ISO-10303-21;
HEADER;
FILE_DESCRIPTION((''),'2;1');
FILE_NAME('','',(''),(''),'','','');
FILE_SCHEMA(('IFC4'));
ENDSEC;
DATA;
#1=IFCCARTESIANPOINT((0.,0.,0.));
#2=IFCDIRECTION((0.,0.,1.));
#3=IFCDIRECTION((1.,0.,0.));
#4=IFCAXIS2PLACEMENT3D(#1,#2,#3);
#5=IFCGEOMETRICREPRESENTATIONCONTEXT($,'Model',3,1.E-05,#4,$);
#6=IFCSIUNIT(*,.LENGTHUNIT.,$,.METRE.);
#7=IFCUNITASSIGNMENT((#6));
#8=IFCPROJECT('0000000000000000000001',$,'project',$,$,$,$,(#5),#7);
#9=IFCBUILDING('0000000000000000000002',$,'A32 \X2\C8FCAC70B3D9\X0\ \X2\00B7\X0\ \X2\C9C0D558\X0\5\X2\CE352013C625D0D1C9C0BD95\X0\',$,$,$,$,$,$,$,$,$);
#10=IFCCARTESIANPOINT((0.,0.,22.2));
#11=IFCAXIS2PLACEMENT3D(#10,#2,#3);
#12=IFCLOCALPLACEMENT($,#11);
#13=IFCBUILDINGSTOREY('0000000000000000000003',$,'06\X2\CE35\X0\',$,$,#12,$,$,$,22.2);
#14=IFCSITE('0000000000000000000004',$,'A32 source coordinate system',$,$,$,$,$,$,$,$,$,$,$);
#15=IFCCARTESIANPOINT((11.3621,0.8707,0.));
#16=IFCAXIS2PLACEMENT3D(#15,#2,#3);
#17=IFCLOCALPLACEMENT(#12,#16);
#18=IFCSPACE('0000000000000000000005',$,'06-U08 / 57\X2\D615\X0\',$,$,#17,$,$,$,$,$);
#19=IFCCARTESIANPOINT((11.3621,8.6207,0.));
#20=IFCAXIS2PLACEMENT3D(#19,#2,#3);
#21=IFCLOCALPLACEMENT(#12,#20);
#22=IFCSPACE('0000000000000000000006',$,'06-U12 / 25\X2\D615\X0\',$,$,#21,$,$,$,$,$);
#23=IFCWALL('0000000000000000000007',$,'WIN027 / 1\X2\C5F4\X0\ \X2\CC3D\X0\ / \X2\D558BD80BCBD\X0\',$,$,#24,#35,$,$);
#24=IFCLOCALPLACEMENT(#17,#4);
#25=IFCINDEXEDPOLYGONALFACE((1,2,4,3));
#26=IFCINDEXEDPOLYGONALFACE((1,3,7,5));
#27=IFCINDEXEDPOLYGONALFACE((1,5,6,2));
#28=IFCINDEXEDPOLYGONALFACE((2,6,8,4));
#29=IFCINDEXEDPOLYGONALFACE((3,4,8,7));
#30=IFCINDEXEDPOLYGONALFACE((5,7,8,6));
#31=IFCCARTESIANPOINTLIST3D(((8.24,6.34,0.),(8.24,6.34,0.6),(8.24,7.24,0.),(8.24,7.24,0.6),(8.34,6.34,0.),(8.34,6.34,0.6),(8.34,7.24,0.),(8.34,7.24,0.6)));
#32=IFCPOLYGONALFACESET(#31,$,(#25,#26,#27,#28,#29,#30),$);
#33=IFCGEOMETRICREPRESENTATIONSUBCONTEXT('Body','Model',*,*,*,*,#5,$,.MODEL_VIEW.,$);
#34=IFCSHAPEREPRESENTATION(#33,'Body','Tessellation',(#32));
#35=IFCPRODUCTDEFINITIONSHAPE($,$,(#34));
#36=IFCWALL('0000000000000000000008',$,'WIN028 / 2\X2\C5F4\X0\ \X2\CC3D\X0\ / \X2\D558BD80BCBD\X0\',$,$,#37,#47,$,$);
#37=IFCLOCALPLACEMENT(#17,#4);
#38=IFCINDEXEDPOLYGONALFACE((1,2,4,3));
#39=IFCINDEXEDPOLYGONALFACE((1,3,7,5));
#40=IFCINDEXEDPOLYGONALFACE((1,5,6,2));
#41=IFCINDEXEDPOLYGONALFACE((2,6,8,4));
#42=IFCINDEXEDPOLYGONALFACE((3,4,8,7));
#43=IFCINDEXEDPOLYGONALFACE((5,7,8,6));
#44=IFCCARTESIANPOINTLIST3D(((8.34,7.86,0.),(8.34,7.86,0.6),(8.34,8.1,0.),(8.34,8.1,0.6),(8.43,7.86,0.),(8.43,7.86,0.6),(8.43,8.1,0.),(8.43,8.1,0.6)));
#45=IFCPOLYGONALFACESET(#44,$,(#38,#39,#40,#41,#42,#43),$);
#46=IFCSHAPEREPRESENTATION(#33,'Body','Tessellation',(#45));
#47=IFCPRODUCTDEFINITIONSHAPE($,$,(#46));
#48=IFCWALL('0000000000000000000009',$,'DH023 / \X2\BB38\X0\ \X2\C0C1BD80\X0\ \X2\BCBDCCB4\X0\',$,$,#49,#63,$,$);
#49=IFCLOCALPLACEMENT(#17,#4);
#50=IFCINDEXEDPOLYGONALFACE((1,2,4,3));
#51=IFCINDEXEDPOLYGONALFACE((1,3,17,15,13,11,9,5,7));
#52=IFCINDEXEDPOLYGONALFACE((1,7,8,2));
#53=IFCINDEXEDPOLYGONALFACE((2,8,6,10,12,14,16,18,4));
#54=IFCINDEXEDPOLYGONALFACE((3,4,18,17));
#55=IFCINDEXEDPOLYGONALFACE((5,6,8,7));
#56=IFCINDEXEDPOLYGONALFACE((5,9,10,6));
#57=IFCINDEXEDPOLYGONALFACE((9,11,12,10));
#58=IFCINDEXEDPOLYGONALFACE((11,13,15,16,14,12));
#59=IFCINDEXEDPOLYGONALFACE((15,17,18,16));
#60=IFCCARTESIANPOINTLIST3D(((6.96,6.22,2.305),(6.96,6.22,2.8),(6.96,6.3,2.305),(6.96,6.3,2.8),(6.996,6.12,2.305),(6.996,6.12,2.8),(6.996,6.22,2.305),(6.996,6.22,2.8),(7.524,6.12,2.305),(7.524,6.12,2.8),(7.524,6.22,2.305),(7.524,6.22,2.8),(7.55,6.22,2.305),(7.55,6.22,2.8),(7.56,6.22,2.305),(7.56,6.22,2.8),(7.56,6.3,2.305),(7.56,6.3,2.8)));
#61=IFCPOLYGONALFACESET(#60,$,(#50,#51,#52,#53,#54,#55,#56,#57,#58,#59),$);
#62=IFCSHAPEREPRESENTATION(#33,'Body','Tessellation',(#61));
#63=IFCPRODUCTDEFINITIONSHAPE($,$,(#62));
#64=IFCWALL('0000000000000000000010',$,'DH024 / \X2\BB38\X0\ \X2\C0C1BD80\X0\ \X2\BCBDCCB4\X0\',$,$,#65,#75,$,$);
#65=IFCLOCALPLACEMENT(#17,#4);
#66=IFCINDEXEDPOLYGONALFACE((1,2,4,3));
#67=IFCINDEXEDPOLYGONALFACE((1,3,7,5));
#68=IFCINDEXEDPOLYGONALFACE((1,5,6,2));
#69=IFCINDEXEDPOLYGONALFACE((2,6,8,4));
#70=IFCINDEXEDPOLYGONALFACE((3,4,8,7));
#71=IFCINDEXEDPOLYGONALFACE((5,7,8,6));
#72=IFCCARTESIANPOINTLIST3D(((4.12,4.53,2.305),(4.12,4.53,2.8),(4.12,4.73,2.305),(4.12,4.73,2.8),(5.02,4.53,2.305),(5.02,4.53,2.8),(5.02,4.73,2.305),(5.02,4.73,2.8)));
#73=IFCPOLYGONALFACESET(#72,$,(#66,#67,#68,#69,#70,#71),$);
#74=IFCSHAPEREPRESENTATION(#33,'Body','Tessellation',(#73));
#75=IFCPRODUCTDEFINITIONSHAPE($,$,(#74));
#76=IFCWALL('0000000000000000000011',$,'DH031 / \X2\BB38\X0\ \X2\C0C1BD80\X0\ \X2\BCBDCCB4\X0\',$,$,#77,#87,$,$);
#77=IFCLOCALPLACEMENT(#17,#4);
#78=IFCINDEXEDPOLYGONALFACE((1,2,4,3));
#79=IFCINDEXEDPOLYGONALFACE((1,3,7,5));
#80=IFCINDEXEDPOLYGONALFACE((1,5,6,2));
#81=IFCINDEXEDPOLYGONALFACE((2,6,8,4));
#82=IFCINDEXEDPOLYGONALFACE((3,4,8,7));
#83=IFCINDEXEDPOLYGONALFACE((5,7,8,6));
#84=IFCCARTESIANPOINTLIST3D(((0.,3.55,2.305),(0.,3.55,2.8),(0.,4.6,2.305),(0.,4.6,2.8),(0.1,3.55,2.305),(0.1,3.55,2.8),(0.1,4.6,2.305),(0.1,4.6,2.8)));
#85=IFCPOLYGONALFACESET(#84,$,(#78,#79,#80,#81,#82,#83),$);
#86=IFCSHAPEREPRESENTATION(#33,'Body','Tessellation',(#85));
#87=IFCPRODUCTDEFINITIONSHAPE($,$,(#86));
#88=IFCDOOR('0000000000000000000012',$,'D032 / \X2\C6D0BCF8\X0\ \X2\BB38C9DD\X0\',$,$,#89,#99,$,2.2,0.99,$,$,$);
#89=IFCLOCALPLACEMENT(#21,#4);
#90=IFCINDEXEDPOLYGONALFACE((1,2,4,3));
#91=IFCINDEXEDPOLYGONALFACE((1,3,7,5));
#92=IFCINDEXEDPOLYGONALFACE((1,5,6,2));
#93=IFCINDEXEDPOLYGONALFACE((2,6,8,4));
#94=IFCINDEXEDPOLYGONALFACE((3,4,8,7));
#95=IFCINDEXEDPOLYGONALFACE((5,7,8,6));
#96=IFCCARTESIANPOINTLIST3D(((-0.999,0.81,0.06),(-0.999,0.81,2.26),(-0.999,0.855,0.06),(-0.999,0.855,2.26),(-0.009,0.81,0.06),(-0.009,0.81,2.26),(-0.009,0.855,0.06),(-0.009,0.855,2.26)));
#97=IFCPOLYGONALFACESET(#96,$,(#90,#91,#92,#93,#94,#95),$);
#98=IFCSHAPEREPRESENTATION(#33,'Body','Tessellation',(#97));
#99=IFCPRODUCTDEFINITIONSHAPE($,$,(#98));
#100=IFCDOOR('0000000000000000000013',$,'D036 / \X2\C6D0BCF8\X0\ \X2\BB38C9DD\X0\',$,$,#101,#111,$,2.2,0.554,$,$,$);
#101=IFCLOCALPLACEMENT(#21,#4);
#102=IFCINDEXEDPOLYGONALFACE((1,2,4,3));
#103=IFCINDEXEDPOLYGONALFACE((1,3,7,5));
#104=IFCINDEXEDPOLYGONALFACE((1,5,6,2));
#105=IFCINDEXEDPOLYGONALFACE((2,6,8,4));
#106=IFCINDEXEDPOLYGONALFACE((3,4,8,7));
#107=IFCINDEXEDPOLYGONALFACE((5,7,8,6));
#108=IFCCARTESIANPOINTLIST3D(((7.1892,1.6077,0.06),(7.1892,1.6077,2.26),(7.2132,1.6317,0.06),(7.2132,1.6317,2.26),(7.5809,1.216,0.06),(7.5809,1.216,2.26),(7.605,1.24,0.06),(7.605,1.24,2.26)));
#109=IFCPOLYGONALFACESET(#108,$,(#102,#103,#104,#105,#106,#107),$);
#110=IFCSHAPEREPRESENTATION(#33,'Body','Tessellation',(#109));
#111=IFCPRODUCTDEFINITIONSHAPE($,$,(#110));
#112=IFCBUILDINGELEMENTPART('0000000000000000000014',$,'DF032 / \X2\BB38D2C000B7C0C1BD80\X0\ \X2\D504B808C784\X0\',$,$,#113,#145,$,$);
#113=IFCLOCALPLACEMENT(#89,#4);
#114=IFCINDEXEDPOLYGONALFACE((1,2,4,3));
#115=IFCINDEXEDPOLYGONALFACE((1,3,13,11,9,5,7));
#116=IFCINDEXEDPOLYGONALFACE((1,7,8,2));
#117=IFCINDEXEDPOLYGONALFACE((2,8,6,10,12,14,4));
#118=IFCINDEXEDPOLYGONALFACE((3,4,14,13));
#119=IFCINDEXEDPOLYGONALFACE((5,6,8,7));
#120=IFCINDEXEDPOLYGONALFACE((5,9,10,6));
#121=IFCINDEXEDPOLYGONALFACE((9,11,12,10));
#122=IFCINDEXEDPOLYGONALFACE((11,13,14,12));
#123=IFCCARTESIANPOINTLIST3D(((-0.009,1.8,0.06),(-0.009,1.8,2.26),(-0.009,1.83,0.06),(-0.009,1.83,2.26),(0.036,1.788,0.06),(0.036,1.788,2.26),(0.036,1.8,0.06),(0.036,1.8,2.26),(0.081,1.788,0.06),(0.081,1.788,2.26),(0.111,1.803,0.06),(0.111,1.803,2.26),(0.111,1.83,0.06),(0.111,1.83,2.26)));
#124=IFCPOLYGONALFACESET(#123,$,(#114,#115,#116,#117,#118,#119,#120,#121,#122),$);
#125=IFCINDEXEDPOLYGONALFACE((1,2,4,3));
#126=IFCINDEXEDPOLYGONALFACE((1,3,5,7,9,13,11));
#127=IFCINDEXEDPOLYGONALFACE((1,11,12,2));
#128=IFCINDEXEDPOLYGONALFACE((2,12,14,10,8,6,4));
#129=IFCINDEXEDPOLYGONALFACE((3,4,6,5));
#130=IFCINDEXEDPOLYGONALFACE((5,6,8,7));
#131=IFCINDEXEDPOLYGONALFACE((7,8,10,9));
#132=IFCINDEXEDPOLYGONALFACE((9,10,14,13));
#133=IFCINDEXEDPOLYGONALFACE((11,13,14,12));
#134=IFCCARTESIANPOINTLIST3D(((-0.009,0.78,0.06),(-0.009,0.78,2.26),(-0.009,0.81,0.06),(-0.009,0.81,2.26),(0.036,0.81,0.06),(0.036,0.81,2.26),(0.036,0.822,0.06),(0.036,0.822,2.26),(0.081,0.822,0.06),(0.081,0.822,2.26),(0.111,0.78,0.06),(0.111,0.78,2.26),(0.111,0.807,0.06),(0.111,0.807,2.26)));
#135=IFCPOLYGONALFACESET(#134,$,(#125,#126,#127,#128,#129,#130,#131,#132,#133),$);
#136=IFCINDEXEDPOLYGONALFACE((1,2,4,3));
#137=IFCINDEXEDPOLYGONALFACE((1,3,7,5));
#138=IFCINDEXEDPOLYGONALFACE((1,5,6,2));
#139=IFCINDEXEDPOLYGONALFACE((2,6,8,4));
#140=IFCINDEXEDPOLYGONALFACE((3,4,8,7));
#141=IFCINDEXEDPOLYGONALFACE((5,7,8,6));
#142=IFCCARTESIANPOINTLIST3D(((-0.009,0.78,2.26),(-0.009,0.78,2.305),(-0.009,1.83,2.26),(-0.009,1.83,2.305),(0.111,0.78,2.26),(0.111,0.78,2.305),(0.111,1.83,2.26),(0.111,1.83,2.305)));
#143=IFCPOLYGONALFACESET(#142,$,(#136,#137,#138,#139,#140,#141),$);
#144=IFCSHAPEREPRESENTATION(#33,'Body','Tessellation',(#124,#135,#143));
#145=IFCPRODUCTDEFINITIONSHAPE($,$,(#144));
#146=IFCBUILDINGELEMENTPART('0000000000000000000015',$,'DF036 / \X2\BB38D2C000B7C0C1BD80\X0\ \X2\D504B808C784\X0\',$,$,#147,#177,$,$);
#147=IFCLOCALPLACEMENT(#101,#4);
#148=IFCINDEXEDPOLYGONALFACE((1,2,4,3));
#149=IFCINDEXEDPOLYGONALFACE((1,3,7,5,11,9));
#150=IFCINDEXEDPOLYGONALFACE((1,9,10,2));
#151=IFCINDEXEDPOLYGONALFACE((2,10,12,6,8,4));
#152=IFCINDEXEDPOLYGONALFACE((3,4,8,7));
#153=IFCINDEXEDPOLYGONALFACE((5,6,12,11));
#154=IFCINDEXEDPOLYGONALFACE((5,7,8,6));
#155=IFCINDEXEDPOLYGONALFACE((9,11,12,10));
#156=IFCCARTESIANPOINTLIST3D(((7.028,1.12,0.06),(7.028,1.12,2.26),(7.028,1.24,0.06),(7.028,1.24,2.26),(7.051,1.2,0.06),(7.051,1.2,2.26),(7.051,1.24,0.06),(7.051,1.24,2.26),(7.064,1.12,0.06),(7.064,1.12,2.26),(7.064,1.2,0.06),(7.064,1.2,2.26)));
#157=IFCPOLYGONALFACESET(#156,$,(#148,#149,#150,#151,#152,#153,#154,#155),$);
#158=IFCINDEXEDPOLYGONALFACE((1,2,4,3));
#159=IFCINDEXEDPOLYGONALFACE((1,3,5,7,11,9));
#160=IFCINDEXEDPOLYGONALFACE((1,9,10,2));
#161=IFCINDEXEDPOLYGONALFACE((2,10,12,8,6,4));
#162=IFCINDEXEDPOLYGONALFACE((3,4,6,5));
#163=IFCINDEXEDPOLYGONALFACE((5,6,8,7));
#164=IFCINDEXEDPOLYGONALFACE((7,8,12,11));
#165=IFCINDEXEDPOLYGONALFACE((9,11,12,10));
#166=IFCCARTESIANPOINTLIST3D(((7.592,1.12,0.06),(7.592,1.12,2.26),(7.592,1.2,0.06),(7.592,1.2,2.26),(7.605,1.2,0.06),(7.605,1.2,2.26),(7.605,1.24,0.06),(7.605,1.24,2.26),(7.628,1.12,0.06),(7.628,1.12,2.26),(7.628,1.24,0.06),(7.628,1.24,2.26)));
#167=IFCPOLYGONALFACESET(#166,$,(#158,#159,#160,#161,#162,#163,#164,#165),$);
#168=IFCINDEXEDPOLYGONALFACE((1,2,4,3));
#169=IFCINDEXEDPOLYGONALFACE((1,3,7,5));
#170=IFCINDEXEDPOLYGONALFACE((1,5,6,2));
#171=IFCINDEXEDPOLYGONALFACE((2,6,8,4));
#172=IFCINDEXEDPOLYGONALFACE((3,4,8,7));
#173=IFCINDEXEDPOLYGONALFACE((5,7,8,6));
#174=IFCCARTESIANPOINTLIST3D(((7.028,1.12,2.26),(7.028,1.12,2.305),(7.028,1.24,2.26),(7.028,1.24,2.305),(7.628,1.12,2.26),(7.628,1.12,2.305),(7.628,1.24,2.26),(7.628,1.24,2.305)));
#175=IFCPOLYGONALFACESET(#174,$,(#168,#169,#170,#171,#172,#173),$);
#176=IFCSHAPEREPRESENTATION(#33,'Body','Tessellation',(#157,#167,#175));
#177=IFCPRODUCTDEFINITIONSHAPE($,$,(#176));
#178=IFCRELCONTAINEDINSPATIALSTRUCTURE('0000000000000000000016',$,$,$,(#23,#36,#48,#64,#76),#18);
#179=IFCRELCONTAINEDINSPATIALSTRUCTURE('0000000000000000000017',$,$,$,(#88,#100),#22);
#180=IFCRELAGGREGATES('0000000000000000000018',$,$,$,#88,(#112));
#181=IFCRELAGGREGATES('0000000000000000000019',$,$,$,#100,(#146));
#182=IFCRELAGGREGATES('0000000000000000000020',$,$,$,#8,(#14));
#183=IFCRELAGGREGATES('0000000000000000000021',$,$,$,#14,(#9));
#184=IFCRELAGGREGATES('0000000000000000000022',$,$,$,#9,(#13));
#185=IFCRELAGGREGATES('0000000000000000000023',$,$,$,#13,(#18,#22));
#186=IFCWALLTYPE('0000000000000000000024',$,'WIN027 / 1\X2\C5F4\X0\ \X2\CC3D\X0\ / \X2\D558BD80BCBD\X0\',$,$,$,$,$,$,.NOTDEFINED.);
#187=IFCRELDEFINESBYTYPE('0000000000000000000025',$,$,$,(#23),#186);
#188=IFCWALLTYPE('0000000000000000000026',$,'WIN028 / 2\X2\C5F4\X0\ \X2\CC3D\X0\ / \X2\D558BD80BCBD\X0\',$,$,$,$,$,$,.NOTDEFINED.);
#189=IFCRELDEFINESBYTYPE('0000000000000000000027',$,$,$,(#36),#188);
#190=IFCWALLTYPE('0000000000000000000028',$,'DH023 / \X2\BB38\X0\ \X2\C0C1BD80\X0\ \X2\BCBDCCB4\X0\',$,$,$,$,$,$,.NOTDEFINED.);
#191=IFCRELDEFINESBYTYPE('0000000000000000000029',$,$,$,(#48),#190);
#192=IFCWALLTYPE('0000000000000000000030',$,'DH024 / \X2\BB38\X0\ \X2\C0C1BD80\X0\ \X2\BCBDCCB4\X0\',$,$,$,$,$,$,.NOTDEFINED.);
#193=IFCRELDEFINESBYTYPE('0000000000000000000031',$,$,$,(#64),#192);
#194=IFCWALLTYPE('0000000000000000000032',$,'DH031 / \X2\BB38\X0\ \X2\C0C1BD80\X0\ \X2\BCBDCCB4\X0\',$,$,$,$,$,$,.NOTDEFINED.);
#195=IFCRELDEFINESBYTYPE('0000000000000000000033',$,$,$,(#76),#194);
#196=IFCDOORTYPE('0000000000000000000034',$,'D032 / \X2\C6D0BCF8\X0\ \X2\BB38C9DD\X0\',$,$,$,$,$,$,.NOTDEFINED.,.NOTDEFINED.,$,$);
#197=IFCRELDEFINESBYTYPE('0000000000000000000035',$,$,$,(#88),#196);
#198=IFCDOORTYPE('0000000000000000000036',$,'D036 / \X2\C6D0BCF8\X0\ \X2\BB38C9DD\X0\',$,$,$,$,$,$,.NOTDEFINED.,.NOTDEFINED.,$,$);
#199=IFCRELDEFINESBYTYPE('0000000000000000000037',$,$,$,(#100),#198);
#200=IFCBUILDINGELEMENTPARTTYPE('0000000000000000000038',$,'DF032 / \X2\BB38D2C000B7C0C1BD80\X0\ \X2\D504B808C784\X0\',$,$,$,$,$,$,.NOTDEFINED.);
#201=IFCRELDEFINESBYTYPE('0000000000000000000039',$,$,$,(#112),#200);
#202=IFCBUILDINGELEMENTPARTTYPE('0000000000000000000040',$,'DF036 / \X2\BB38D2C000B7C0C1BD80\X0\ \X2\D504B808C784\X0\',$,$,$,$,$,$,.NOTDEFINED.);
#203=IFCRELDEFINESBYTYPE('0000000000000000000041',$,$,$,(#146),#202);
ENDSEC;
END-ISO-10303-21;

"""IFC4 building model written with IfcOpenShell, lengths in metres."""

from ifc_helpers import new_model, si_unit, frame, origin, origin_with_axes, place, context, subcontext, project, spatial, polyline, outline, extrude, source, transform, mapped, type_object, type_shapes, element, aggregate, save


model = new_model("IFC4")

# Units and contexts
model_context = context("Model", 3, precision=1e-05, world=origin_with_axes())
body_context = subcontext(model_context, "Body", "Model", "MODEL_VIEW")
ifc_project = project(units=[si_unit("LENGTHUNIT", "METRE")], contexts=[model_context])

# Site, building, storey, space
storey_placement = place(None, frame((0.0, 0.0, 22.2), z_axis=(0.0, 0.0, 1.0), x_axis=(1.0, 0.0, 0.0)))
space_1_placement = place(storey_placement, frame((11.3621, 8.6207, 0.0), z_axis=(0.0, 0.0, 1.0), x_axis=(1.0, 0.0, 0.0)))
site = spatial("IfcSite", under=ifc_project, Name="A32 source coordinate system")
building = spatial("IfcBuilding", under=site, Name="A32 주거동 · 지하5층–옥탑지붕")
storey = spatial("IfcBuildingStorey", under=building, at=storey_placement, Name="06층", Elevation=22.2)
space_2_placement = place(storey_placement, frame((11.3621, 0.8707, 0.0), z_axis=(0.0, 0.0, 1.0), x_axis=(1.0, 0.0, 0.0)))
space_2 = spatial("IfcSpace", under=storey, at=space_2_placement, Name="06-U08 / 57형")

# Walls
wall_type_1 = type_object("IfcWallType", Name="WIN027 / 1열 창 / 하부벽", PredefinedType="NOTDEFINED")
shared_shape_1 = source(origin(), body_context, "Body", "SweptSolid", [
    extrude(outline(polyline([(8.24, 6.34), (8.24, 7.24), (8.34, 7.24), (8.34, 6.34), (8.24, 6.34)])), origin(), (0.0, 0.0, 1.0), 0.6),
])
type_shapes(wall_type_1, [shared_shape_1])
wall_1_placement = place(space_2_placement, origin_with_axes())
element("IfcWall", 1, at=wall_1_placement, inside=space_2, type_object=wall_type_1, Name="WIN027 / 1열 창 / 하부벽", context=body_context, shape_type="MappedRepresentation", body=[
    mapped(shared_shape_1, transform((0.0, 0.0, 0.0), scale=1.0)),
])
wall_type_2 = type_object("IfcWallType", Name="WIN028 / 2열 창 / 하부벽", PredefinedType="NOTDEFINED")
shared_shape_2 = source(origin(), body_context, "Body", "SweptSolid", [
    extrude(outline(polyline([(8.34, 7.86), (8.34, 8.1), (8.43, 8.1), (8.43, 7.86), (8.34, 7.86)])), origin(), (0.0, 0.0, 1.0), 0.6),
])
type_shapes(wall_type_2, [shared_shape_2])
wall_2_placement = place(space_2_placement, origin_with_axes())
element("IfcWall", 2, at=wall_2_placement, inside=space_2, type_object=wall_type_2, Name="WIN028 / 2열 창 / 하부벽", context=body_context, shape_type="MappedRepresentation", body=[
    mapped(shared_shape_2, transform((0.0, 0.0, 0.0), scale=1.0)),
])
wall_type_3 = type_object("IfcWallType", Name="DH023 / 문 상부 벽체", PredefinedType="NOTDEFINED")
shared_shape_3 = source(origin(), body_context, "Body", "SweptSolid", [
    extrude(outline(polyline([(6.96, 6.3), (7.56, 6.3), (7.56, 6.22), (7.55, 6.22), (7.524, 6.22), (7.524, 6.12), (6.996, 6.12), (6.996, 6.22), (6.96, 6.22), (6.96, 6.3)])), frame((0.0, 0.0, 2.305)), (0.0, 0.0, 1.0), 0.495),
])
type_shapes(wall_type_3, [shared_shape_3])
wall_3_placement = place(space_2_placement, origin_with_axes())
element("IfcWall", 3, at=wall_3_placement, inside=space_2, type_object=wall_type_3, Name="DH023 / 문 상부 벽체", context=body_context, shape_type="MappedRepresentation", body=[
    mapped(shared_shape_3, transform((0.0, 0.0, 0.0), scale=1.0)),
])
wall_type_4 = type_object("IfcWallType", Name="DH024 / 문 상부 벽체", PredefinedType="NOTDEFINED")
shared_shape_4 = source(origin(), body_context, "Body", "SweptSolid", [
    extrude(outline(polyline([(4.12, 4.73), (5.02, 4.73), (5.02, 4.53), (4.12, 4.53), (4.12, 4.73)])), frame((0.0, 0.0, 2.305)), (0.0, 0.0, 1.0), 0.495),
])
type_shapes(wall_type_4, [shared_shape_4])
wall_4_placement = place(space_2_placement, origin_with_axes())
element("IfcWall", 4, at=wall_4_placement, inside=space_2, type_object=wall_type_4, Name="DH024 / 문 상부 벽체", context=body_context, shape_type="MappedRepresentation", body=[
    mapped(shared_shape_4, transform((0.0, 0.0, 0.0), scale=1.0)),
])
wall_type_5 = type_object("IfcWallType", Name="DH031 / 문 상부 벽체", PredefinedType="NOTDEFINED")
shared_shape_5 = source(origin(), body_context, "Body", "SweptSolid", [
    extrude(outline(polyline([(0.0, 4.6), (0.1, 4.6), (0.1, 3.55), (0.0, 3.55), (0.0, 4.6)])), frame((0.0, 0.0, 2.305)), (0.0, 0.0, 1.0), 0.495),
])
type_shapes(wall_type_5, [shared_shape_5])
wall_5_placement = place(space_2_placement, origin_with_axes())
element("IfcWall", 5, at=wall_5_placement, inside=space_2, type_object=wall_type_5, Name="DH031 / 문 상부 벽체", context=body_context, shape_type="MappedRepresentation", body=[
    mapped(shared_shape_5, transform((0.0, 0.0, 0.0), scale=1.0)),
])

# Shared definitions
space_1 = spatial("IfcSpace", under=storey, at=space_1_placement, Name="06-U12 / 25형")

# Doors
door_type_1 = type_object("IfcDoorType", Name="D032 / 원본 문짝", OperationType="NOTDEFINED", PredefinedType="NOTDEFINED")
shared_shape_6 = source(origin(), body_context, "Body", "SweptSolid", [
    extrude(outline(polyline([(-0.009, 0.81), (-0.999, 0.81), (-0.999, 0.855), (-0.009, 0.855), (-0.009, 0.81)])), frame((0.0, 0.0, 0.06)), (0.0, 0.0, 1.0), 2.2),
])
type_shapes(door_type_1, [shared_shape_6])
door_1_placement = place(space_1_placement, origin_with_axes())
door_1 = element("IfcDoor", 6, at=door_1_placement, inside=space_1, type_object=door_type_1, Name="D032 / 원본 문짝", OverallHeight=2.2, OverallWidth=0.99, context=body_context, shape_type="MappedRepresentation", body=[
    mapped(shared_shape_6, transform((0.0, 0.0, 0.0), scale=1.0)),
])
door_type_2 = type_object("IfcDoorType", Name="D036 / 원본 문짝", OperationType="NOTDEFINED", PredefinedType="NOTDEFINED")
shared_shape_7 = source(origin(), body_context, "Body", "SweptSolid", [
    extrude(outline(polyline([(7.1892, 1.6077), (7.2132, 1.6317), (7.605, 1.24), (7.5809, 1.216), (7.1892, 1.6077)])), frame((0.0, 0.0, 0.06)), (0.0, 0.0, 1.0), 2.2),
])
type_shapes(door_type_2, [shared_shape_7])
door_2_placement = place(space_1_placement, origin_with_axes())
door_2 = element("IfcDoor", 7, at=door_2_placement, inside=space_1, type_object=door_type_2, Name="D036 / 원본 문짝", OverallHeight=2.2, OverallWidth=0.554, context=body_context, shape_type="MappedRepresentation", body=[
    mapped(shared_shape_7, transform((0.0, 0.0, 0.0), scale=1.0)),
])

# Building element parts
building_element_part_type_1 = type_object("IfcBuildingElementPartType", Name="DF032 / 문틀·상부 프레임", PredefinedType="NOTDEFINED")
shared_shape_8 = source(origin(), body_context, "Body", "SweptSolid", [
    extrude(outline(polyline([(0.111, 1.83), (0.111, 1.803), (0.081, 1.788), (0.036, 1.788), (0.036, 1.8), (-0.009, 1.8), (-0.009, 1.83), (0.111, 1.83)])), frame((0.0, 0.0, 0.06)), (0.0, 0.0, 1.0), 2.2),
    extrude(outline(polyline([(-0.009, 0.81), (0.036, 0.81), (0.036, 0.822), (0.081, 0.822), (0.111, 0.807), (0.111, 0.78), (-0.009, 0.78), (-0.009, 0.81)])), frame((0.0, 0.0, 0.06)), (0.0, 0.0, 1.0), 2.2),
    extrude(outline(polyline([(-0.009, 0.78), (-0.009, 1.83), (0.111, 1.83), (0.111, 0.78), (-0.009, 0.78)])), frame((0.0, 0.0, 2.26)), (0.0, 0.0, 1.0), 0.045),
])
type_shapes(building_element_part_type_1, [shared_shape_8])
building_element_part_1_placement = place(door_1_placement, origin_with_axes())
building_element_part_1 = element("IfcBuildingElementPart", 8, at=building_element_part_1_placement, type_object=building_element_part_type_1, Name="DF032 / 문틀·상부 프레임", context=body_context, shape_type="MappedRepresentation", body=[
    mapped(shared_shape_8, transform((0.0, 0.0, 0.0), scale=1.0)),
])
aggregate(door_1, [building_element_part_1])
building_element_part_type_2 = type_object("IfcBuildingElementPartType", Name="DF036 / 문틀·상부 프레임", PredefinedType="NOTDEFINED")
shared_shape_9 = source(origin(), body_context, "Body", "SweptSolid", [
    extrude(outline(polyline([(7.028, 1.24), (7.051, 1.24), (7.051, 1.2), (7.064, 1.2), (7.064, 1.12), (7.028, 1.12), (7.028, 1.24)])), frame((0.0, 0.0, 0.06)), (0.0, 0.0, 1.0), 2.2),
    extrude(outline(polyline([(7.592, 1.12), (7.592, 1.2), (7.605, 1.2), (7.605, 1.24), (7.628, 1.24), (7.628, 1.12), (7.592, 1.12)])), frame((0.0, 0.0, 0.06)), (0.0, 0.0, 1.0), 2.2),
    extrude(outline(polyline([(7.028, 1.12), (7.028, 1.24), (7.628, 1.24), (7.628, 1.12), (7.028, 1.12)])), frame((0.0, 0.0, 2.26)), (0.0, 0.0, 1.0), 0.045),
])
type_shapes(building_element_part_type_2, [shared_shape_9])
building_element_part_2_placement = place(door_2_placement, origin_with_axes())
building_element_part_2 = element("IfcBuildingElementPart", 9, at=building_element_part_2_placement, type_object=building_element_part_type_2, Name="DF036 / 문틀·상부 프레임", context=body_context, shape_type="MappedRepresentation", body=[
    mapped(shared_shape_9, transform((0.0, 0.0, 0.0), scale=1.0)),
])
aggregate(door_2, [building_element_part_2])

save(model, "model.ifc")
